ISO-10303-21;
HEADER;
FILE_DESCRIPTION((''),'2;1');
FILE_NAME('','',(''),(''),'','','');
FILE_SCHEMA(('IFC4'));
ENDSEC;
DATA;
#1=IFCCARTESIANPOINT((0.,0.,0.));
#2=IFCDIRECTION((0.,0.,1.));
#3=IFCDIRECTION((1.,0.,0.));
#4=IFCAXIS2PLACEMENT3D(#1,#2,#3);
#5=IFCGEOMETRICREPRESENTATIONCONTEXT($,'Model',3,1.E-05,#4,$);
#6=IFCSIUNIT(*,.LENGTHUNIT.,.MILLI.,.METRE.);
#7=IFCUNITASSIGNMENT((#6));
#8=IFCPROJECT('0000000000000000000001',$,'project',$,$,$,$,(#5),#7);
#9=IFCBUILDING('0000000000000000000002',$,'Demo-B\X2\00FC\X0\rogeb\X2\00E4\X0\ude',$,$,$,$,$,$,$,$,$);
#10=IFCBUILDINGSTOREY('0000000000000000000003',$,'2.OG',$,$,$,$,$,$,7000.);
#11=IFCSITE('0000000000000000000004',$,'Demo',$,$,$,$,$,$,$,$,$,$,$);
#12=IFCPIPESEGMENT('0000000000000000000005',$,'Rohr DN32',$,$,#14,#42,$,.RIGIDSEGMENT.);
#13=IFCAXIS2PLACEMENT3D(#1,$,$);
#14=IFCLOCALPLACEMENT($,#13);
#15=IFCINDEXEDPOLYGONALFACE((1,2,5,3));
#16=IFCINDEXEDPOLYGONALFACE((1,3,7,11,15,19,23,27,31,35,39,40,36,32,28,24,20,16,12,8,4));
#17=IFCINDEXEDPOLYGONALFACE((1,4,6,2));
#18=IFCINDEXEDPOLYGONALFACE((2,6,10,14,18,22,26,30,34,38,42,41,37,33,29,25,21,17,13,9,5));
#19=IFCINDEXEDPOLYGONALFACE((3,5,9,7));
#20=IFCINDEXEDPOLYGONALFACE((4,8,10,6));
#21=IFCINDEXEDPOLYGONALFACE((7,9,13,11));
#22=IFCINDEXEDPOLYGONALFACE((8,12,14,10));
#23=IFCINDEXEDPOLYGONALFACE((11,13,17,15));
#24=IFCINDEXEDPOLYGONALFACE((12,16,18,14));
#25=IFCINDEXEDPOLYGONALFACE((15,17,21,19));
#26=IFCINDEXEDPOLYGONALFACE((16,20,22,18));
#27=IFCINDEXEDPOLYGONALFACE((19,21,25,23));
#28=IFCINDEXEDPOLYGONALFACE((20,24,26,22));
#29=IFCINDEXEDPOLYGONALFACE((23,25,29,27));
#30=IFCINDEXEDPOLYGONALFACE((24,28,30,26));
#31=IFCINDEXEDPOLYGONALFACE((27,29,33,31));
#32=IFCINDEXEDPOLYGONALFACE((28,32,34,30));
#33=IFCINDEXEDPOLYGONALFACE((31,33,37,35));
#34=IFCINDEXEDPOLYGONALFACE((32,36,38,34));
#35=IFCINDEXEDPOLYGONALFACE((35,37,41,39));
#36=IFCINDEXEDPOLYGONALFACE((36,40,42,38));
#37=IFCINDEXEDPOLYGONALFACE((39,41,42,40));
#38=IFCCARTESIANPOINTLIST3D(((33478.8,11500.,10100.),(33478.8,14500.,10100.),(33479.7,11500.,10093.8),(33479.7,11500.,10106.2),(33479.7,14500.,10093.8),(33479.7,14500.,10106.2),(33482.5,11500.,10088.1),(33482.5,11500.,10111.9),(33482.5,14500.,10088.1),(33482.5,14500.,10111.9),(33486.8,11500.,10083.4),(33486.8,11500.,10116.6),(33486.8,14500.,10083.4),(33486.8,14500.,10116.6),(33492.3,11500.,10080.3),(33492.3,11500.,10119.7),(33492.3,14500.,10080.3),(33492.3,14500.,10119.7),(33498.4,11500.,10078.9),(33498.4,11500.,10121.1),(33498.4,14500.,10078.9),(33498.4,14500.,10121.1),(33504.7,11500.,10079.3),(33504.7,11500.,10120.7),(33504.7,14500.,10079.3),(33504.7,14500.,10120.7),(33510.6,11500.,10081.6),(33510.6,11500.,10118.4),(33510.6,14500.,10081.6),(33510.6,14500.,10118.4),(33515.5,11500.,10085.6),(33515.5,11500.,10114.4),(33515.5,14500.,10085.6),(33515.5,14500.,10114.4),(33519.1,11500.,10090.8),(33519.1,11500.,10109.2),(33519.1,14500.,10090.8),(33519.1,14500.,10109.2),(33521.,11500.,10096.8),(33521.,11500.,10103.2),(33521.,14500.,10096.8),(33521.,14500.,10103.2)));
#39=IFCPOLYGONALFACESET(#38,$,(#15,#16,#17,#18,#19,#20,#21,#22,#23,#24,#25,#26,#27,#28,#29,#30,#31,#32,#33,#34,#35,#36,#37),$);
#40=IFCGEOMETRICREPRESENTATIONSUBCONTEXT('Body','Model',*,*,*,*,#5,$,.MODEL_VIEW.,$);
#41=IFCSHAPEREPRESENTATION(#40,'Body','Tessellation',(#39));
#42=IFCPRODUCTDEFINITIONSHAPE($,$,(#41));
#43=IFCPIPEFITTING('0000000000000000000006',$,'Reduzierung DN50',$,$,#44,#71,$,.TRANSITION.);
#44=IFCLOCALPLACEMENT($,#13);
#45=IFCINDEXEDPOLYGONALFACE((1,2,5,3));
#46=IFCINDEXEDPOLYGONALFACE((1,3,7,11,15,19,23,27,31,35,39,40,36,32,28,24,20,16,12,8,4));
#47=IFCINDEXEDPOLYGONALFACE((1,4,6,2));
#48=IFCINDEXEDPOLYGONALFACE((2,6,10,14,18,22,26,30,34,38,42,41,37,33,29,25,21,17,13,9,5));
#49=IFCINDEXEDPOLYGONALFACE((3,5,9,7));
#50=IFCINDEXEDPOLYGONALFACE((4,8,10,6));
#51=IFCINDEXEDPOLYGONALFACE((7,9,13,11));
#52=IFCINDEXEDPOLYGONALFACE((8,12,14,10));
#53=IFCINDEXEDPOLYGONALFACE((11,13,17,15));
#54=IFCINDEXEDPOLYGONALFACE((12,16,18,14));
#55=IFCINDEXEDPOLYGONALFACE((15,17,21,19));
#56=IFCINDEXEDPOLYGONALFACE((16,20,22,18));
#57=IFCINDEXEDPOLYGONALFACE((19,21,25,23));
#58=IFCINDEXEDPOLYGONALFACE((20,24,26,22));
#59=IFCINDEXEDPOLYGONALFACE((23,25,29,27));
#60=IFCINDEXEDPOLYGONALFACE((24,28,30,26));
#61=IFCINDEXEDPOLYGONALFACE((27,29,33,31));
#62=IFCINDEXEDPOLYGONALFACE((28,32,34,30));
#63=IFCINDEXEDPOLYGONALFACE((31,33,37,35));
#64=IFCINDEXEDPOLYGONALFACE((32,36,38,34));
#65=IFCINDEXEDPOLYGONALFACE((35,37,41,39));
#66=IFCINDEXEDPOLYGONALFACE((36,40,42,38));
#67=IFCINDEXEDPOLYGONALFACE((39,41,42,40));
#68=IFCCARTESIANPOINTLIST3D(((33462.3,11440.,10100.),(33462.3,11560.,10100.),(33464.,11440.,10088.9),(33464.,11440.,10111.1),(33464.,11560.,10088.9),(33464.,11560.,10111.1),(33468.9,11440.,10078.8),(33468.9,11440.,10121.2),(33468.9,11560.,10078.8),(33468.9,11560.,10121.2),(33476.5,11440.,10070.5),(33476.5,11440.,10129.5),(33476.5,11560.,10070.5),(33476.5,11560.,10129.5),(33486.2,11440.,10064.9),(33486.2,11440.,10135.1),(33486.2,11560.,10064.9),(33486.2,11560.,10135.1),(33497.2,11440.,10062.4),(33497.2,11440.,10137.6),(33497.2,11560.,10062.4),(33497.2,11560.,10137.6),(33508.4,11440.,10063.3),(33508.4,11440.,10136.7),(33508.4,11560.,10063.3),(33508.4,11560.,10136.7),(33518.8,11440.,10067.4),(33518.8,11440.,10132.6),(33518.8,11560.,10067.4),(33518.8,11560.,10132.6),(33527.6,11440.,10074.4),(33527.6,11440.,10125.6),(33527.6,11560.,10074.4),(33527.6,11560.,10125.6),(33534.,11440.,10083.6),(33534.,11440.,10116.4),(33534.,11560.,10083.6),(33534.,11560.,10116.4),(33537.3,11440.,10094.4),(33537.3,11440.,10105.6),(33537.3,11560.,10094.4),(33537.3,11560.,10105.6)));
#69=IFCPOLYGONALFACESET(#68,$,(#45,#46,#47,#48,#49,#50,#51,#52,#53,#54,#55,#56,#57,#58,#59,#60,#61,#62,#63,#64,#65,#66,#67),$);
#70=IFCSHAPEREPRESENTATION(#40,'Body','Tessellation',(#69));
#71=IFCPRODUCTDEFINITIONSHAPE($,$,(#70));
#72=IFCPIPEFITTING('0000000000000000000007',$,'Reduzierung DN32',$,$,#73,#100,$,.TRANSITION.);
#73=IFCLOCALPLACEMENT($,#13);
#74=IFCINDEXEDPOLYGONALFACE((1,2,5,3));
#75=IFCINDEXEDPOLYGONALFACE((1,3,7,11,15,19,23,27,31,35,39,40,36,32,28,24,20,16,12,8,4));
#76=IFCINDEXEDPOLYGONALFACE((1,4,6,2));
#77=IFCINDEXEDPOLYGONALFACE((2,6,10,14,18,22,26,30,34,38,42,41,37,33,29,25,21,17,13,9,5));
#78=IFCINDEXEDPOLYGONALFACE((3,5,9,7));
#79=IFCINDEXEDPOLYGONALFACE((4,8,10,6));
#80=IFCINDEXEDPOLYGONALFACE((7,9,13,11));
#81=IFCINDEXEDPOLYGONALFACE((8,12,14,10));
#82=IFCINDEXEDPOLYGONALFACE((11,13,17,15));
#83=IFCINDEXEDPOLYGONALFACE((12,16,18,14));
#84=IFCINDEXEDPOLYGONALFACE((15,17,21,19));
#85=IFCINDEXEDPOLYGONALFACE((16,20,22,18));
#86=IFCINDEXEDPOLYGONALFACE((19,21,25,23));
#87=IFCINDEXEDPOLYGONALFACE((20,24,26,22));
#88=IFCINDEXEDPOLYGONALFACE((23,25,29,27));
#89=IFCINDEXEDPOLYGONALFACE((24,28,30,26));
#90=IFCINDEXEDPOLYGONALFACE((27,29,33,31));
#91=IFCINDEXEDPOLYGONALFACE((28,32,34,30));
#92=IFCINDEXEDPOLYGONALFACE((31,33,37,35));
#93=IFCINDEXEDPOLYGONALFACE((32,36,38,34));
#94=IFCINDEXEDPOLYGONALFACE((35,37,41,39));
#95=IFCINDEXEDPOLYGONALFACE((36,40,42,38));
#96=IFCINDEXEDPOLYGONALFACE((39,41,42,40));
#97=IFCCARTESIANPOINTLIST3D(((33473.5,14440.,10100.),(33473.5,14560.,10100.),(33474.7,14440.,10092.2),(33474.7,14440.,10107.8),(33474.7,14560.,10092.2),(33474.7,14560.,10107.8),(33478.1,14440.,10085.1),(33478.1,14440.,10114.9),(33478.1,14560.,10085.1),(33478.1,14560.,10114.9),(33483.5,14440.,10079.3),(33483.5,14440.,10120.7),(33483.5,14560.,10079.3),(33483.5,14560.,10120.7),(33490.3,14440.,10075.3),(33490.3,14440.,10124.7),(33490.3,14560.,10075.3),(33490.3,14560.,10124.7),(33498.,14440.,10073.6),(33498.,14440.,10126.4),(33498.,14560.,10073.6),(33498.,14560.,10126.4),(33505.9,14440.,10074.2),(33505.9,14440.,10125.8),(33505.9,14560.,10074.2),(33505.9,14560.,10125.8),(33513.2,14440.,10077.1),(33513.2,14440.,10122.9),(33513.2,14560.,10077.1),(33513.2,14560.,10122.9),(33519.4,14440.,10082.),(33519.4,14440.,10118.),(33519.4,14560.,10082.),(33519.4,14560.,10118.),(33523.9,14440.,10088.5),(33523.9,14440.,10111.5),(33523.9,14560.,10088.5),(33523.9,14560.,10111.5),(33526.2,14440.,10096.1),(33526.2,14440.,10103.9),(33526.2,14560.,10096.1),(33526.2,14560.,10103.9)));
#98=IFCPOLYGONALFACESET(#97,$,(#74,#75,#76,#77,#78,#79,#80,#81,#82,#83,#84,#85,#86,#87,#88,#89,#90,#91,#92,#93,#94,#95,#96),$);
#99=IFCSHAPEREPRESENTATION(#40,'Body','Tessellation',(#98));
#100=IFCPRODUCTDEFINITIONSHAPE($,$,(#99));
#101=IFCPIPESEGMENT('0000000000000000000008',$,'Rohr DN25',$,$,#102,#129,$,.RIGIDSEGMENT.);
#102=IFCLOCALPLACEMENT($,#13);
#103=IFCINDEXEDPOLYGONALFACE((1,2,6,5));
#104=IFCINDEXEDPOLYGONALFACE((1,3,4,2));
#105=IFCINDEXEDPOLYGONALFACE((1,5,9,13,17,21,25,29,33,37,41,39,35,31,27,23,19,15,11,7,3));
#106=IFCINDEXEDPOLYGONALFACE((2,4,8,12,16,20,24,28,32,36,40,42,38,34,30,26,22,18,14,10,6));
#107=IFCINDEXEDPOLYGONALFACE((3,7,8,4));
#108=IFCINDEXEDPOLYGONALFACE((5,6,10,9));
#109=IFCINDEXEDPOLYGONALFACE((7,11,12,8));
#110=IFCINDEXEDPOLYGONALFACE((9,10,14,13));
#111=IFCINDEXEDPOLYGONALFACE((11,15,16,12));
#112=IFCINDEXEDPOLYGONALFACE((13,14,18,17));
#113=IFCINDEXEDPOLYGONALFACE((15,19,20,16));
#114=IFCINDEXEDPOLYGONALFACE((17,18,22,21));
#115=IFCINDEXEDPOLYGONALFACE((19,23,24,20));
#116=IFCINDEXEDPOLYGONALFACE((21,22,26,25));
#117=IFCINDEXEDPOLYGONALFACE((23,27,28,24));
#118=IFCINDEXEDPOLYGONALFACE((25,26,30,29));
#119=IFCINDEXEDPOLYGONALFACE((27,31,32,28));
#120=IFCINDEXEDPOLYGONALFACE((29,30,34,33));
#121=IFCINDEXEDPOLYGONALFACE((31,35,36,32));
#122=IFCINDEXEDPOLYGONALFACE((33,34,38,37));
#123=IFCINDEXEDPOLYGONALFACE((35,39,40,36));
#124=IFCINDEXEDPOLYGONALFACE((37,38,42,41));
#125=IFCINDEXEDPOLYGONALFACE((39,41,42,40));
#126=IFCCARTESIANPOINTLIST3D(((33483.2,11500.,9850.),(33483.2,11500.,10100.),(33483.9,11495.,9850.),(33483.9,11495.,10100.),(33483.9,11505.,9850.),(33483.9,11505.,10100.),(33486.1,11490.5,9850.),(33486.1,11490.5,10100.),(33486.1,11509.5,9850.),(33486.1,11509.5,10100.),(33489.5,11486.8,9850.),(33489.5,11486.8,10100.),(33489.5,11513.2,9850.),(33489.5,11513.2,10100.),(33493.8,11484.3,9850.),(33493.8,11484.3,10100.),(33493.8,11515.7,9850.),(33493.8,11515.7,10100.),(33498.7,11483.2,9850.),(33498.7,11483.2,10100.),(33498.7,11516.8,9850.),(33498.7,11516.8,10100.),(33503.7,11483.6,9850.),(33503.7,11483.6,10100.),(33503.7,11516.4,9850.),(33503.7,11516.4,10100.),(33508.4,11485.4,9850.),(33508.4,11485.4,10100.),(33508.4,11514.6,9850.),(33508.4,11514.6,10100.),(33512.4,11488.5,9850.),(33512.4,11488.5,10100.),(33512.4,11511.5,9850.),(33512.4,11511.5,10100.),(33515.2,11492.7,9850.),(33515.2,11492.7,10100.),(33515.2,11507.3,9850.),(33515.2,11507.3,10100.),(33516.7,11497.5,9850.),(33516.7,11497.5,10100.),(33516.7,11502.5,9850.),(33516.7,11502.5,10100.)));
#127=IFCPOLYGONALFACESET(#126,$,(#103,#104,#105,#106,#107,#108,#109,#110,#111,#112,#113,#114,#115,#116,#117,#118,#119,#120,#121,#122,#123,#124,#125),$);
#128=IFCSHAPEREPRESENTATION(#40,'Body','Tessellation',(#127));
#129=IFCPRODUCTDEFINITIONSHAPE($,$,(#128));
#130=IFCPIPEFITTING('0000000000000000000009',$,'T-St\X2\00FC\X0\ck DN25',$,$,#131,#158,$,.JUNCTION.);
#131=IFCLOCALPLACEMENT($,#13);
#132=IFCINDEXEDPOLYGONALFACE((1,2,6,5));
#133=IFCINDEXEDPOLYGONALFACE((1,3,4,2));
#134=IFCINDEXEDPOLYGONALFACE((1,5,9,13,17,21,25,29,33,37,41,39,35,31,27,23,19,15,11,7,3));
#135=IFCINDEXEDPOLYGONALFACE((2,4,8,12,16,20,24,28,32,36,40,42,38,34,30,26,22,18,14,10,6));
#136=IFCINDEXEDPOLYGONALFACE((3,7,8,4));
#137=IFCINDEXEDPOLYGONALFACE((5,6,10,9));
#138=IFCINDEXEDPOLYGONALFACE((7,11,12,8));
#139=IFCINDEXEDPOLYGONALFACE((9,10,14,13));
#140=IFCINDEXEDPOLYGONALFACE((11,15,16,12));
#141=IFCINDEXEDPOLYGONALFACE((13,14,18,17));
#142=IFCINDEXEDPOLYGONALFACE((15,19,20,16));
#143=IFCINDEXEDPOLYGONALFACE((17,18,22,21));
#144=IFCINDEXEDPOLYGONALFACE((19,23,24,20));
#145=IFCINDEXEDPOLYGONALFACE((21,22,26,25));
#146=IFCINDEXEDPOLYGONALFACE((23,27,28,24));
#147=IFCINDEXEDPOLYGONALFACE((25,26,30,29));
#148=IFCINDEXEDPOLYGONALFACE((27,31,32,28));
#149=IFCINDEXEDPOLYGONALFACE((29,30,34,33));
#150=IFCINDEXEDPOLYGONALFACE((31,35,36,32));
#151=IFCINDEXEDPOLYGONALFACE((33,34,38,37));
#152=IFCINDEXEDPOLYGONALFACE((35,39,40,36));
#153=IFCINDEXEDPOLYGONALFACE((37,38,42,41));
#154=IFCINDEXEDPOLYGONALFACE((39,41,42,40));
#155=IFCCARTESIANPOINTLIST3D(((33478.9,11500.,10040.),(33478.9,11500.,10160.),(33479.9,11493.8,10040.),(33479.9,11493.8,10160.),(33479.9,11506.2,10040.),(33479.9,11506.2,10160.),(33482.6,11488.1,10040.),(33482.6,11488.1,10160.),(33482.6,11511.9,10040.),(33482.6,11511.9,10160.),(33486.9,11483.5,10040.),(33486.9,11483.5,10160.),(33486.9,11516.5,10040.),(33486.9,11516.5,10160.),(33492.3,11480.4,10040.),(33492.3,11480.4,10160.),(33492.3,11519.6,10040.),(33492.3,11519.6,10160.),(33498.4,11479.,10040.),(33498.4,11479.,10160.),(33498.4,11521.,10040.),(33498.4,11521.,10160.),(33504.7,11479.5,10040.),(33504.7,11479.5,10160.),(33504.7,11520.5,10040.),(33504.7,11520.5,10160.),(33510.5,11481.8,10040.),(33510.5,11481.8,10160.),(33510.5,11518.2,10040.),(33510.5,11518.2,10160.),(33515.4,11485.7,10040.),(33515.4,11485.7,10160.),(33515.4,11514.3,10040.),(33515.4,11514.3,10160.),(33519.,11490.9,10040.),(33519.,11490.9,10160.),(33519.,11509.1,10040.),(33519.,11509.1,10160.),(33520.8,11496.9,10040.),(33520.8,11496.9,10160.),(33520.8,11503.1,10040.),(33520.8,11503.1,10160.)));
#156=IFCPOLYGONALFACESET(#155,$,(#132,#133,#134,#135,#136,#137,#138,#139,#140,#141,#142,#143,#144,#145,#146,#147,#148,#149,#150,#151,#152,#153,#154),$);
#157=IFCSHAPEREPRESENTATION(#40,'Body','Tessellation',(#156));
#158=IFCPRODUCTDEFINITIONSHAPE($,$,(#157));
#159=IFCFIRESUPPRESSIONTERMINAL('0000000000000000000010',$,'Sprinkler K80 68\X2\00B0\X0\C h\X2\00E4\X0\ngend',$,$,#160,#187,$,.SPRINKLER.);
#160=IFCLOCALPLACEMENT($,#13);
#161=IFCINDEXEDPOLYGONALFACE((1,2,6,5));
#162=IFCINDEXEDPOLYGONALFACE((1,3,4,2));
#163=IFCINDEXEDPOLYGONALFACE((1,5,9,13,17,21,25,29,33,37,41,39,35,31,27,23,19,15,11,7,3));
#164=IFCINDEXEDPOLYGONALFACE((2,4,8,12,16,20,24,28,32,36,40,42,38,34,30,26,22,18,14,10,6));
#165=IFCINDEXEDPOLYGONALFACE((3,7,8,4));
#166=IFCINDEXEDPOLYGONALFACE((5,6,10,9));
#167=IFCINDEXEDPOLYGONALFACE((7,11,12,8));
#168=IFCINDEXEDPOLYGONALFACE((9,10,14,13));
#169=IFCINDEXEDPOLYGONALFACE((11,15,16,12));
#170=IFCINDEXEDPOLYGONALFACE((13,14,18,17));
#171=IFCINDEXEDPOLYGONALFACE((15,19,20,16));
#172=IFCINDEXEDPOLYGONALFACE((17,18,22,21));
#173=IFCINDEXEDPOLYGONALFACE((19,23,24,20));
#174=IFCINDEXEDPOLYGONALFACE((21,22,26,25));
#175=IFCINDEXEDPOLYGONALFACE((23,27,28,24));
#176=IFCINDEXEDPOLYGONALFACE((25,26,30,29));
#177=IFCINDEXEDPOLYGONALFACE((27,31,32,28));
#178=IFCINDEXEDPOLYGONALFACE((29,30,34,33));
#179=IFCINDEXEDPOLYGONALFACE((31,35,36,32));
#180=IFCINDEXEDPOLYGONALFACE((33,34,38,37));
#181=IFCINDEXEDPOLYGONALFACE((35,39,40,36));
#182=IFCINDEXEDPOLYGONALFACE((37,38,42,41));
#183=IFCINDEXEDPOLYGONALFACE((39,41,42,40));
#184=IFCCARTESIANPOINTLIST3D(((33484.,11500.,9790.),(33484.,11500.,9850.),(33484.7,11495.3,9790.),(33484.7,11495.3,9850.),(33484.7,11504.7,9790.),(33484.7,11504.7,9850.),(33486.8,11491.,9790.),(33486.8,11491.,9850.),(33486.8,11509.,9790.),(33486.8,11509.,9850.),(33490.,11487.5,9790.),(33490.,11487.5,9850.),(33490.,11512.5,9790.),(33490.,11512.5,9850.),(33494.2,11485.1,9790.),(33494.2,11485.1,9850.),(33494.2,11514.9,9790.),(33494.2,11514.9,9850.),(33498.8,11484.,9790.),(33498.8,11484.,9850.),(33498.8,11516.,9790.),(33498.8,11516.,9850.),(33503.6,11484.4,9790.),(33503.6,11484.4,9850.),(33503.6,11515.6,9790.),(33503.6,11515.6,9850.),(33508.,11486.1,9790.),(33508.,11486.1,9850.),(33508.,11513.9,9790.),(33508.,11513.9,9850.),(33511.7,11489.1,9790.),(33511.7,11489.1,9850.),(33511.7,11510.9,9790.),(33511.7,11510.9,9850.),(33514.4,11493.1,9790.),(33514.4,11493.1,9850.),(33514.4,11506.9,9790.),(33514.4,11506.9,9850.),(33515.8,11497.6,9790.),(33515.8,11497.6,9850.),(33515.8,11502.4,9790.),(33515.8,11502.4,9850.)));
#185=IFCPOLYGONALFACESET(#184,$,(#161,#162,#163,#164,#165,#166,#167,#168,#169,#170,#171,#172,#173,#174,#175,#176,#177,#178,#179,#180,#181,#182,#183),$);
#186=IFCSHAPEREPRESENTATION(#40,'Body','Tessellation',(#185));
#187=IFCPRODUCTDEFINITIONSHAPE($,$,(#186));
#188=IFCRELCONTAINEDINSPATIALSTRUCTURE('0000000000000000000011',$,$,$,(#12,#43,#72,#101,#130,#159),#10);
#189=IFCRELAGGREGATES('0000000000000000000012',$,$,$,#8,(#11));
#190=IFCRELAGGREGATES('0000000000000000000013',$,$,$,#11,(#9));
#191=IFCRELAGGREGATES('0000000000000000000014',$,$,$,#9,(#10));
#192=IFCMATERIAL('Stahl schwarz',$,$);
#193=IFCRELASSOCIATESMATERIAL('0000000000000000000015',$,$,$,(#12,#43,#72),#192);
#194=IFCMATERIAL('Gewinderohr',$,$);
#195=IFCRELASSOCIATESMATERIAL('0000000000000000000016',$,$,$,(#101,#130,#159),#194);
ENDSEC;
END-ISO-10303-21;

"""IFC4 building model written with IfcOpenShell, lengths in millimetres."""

from ifc_helpers import new_model, si_unit, frame, origin_with_axes, place, context, subcontext, project, spatial, circle, extrude, material, element, save


model = new_model("IFC4")

# Units and contexts
model_context = context("Model", 3, precision=1e-05, world=origin_with_axes())
body_context = subcontext(model_context, "Body", "Model", "MODEL_VIEW")
ifc_project = project(units=[si_unit("LENGTHUNIT", "METRE", prefix="MILLI")], contexts=[model_context])

# Site, building, storey
site = spatial("IfcSite", under=ifc_project, Name="Demo")
building = spatial("IfcBuilding", under=site, Name="Demo-Bürogebäude")
storey = spatial("IfcBuildingStorey", under=building, Name="2.OG", Elevation=7000.0)

# Shared definitions
ifc_material_1 = material(Name="Gewinderohr")

# Shared definitions
ifc_material_2 = material(Name="Stahl schwarz")

# Pipe segment
pipe_segment_1_placement = place(None, frame((33500.0, 11500.0, 10100.0), z_axis=(0.0, 1.0, 0.0), x_axis=(-1.0, 0.0, 0.0)))
element("IfcPipeSegment", 1, at=pipe_segment_1_placement, inside=storey, material=ifc_material_2, Name="Rohr DN32", PredefinedType="RIGIDSEGMENT", context=body_context, shape_type="SweptSolid", body=[
    extrude(circle(Radius=21.2), origin_with_axes(), (0.0, 0.0, 1.0), 3000.0),
])

# Pipe fittings
pipe_fitting_1_placement = place(None, frame((33500.0, 11440.0, 10100.0), z_axis=(0.0, 1.0, 0.0), x_axis=(-1.0, 0.0, 0.0)))
element("IfcPipeFitting", 2, at=pipe_fitting_1_placement, inside=storey, material=ifc_material_2, Name="Reduzierung DN50", PredefinedType="TRANSITION", context=body_context, shape_type="SweptSolid", body=[
    extrude(circle(Radius=37.7), origin_with_axes(), (0.0, 0.0, 1.0), 120.0),
])
pipe_fitting_2_placement = place(None, frame((33500.0, 14440.0, 10100.0), z_axis=(0.0, 1.0, 0.0), x_axis=(-1.0, 0.0, 0.0)))
element("IfcPipeFitting", 3, at=pipe_fitting_2_placement, inside=storey, material=ifc_material_2, Name="Reduzierung DN32", PredefinedType="TRANSITION", context=body_context, shape_type="SweptSolid", body=[
    extrude(circle(Radius=26.5), origin_with_axes(), (0.0, 0.0, 1.0), 120.0),
])

# Pipe segment
pipe_segment_2_placement = place(None, frame((33500.0, 11500.0, 10100.0), z_axis=(0.0, 0.0, -1.0), x_axis=(-1.0, 0.0, 0.0)))
element("IfcPipeSegment", 4, at=pipe_segment_2_placement, inside=storey, material=ifc_material_1, Name="Rohr DN25", PredefinedType="RIGIDSEGMENT", context=body_context, shape_type="SweptSolid", body=[
    extrude(circle(Radius=16.9), origin_with_axes(), (0.0, 0.0, 1.0), 250.0),
])

# Pipe fitting
pipe_fitting_3_placement = place(None, frame((33500.0, 11500.0, 10160.0), z_axis=(0.0, 0.0, -1.0), x_axis=(-1.0, 0.0, 0.0)))
element("IfcPipeFitting", 5, at=pipe_fitting_3_placement, inside=storey, material=ifc_material_1, Name="T-Stück DN25", PredefinedType="JUNCTION", context=body_context, shape_type="SweptSolid", body=[
    extrude(circle(Radius=21.1), origin_with_axes(), (0.0, 0.0, 1.0), 120.0),
])

# Fire suppression terminal
fire_suppression_terminal_1_placement = place(None, frame((33500.0, 11500.0, 9850.0), z_axis=(0.0, 0.0, -1.0), x_axis=(-1.0, 0.0, 0.0)))
element("IfcFireSuppressionTerminal", 6, at=fire_suppression_terminal_1_placement, inside=storey, material=ifc_material_1, Name="Sprinkler K80 68°C hängend", PredefinedType="SPRINKLER", context=body_context, shape_type="SweptSolid", body=[
    extrude(circle(Radius=16.0), origin_with_axes(), (0.0, 0.0, 1.0), 60.0),
])

save(model, "model.ifc")
